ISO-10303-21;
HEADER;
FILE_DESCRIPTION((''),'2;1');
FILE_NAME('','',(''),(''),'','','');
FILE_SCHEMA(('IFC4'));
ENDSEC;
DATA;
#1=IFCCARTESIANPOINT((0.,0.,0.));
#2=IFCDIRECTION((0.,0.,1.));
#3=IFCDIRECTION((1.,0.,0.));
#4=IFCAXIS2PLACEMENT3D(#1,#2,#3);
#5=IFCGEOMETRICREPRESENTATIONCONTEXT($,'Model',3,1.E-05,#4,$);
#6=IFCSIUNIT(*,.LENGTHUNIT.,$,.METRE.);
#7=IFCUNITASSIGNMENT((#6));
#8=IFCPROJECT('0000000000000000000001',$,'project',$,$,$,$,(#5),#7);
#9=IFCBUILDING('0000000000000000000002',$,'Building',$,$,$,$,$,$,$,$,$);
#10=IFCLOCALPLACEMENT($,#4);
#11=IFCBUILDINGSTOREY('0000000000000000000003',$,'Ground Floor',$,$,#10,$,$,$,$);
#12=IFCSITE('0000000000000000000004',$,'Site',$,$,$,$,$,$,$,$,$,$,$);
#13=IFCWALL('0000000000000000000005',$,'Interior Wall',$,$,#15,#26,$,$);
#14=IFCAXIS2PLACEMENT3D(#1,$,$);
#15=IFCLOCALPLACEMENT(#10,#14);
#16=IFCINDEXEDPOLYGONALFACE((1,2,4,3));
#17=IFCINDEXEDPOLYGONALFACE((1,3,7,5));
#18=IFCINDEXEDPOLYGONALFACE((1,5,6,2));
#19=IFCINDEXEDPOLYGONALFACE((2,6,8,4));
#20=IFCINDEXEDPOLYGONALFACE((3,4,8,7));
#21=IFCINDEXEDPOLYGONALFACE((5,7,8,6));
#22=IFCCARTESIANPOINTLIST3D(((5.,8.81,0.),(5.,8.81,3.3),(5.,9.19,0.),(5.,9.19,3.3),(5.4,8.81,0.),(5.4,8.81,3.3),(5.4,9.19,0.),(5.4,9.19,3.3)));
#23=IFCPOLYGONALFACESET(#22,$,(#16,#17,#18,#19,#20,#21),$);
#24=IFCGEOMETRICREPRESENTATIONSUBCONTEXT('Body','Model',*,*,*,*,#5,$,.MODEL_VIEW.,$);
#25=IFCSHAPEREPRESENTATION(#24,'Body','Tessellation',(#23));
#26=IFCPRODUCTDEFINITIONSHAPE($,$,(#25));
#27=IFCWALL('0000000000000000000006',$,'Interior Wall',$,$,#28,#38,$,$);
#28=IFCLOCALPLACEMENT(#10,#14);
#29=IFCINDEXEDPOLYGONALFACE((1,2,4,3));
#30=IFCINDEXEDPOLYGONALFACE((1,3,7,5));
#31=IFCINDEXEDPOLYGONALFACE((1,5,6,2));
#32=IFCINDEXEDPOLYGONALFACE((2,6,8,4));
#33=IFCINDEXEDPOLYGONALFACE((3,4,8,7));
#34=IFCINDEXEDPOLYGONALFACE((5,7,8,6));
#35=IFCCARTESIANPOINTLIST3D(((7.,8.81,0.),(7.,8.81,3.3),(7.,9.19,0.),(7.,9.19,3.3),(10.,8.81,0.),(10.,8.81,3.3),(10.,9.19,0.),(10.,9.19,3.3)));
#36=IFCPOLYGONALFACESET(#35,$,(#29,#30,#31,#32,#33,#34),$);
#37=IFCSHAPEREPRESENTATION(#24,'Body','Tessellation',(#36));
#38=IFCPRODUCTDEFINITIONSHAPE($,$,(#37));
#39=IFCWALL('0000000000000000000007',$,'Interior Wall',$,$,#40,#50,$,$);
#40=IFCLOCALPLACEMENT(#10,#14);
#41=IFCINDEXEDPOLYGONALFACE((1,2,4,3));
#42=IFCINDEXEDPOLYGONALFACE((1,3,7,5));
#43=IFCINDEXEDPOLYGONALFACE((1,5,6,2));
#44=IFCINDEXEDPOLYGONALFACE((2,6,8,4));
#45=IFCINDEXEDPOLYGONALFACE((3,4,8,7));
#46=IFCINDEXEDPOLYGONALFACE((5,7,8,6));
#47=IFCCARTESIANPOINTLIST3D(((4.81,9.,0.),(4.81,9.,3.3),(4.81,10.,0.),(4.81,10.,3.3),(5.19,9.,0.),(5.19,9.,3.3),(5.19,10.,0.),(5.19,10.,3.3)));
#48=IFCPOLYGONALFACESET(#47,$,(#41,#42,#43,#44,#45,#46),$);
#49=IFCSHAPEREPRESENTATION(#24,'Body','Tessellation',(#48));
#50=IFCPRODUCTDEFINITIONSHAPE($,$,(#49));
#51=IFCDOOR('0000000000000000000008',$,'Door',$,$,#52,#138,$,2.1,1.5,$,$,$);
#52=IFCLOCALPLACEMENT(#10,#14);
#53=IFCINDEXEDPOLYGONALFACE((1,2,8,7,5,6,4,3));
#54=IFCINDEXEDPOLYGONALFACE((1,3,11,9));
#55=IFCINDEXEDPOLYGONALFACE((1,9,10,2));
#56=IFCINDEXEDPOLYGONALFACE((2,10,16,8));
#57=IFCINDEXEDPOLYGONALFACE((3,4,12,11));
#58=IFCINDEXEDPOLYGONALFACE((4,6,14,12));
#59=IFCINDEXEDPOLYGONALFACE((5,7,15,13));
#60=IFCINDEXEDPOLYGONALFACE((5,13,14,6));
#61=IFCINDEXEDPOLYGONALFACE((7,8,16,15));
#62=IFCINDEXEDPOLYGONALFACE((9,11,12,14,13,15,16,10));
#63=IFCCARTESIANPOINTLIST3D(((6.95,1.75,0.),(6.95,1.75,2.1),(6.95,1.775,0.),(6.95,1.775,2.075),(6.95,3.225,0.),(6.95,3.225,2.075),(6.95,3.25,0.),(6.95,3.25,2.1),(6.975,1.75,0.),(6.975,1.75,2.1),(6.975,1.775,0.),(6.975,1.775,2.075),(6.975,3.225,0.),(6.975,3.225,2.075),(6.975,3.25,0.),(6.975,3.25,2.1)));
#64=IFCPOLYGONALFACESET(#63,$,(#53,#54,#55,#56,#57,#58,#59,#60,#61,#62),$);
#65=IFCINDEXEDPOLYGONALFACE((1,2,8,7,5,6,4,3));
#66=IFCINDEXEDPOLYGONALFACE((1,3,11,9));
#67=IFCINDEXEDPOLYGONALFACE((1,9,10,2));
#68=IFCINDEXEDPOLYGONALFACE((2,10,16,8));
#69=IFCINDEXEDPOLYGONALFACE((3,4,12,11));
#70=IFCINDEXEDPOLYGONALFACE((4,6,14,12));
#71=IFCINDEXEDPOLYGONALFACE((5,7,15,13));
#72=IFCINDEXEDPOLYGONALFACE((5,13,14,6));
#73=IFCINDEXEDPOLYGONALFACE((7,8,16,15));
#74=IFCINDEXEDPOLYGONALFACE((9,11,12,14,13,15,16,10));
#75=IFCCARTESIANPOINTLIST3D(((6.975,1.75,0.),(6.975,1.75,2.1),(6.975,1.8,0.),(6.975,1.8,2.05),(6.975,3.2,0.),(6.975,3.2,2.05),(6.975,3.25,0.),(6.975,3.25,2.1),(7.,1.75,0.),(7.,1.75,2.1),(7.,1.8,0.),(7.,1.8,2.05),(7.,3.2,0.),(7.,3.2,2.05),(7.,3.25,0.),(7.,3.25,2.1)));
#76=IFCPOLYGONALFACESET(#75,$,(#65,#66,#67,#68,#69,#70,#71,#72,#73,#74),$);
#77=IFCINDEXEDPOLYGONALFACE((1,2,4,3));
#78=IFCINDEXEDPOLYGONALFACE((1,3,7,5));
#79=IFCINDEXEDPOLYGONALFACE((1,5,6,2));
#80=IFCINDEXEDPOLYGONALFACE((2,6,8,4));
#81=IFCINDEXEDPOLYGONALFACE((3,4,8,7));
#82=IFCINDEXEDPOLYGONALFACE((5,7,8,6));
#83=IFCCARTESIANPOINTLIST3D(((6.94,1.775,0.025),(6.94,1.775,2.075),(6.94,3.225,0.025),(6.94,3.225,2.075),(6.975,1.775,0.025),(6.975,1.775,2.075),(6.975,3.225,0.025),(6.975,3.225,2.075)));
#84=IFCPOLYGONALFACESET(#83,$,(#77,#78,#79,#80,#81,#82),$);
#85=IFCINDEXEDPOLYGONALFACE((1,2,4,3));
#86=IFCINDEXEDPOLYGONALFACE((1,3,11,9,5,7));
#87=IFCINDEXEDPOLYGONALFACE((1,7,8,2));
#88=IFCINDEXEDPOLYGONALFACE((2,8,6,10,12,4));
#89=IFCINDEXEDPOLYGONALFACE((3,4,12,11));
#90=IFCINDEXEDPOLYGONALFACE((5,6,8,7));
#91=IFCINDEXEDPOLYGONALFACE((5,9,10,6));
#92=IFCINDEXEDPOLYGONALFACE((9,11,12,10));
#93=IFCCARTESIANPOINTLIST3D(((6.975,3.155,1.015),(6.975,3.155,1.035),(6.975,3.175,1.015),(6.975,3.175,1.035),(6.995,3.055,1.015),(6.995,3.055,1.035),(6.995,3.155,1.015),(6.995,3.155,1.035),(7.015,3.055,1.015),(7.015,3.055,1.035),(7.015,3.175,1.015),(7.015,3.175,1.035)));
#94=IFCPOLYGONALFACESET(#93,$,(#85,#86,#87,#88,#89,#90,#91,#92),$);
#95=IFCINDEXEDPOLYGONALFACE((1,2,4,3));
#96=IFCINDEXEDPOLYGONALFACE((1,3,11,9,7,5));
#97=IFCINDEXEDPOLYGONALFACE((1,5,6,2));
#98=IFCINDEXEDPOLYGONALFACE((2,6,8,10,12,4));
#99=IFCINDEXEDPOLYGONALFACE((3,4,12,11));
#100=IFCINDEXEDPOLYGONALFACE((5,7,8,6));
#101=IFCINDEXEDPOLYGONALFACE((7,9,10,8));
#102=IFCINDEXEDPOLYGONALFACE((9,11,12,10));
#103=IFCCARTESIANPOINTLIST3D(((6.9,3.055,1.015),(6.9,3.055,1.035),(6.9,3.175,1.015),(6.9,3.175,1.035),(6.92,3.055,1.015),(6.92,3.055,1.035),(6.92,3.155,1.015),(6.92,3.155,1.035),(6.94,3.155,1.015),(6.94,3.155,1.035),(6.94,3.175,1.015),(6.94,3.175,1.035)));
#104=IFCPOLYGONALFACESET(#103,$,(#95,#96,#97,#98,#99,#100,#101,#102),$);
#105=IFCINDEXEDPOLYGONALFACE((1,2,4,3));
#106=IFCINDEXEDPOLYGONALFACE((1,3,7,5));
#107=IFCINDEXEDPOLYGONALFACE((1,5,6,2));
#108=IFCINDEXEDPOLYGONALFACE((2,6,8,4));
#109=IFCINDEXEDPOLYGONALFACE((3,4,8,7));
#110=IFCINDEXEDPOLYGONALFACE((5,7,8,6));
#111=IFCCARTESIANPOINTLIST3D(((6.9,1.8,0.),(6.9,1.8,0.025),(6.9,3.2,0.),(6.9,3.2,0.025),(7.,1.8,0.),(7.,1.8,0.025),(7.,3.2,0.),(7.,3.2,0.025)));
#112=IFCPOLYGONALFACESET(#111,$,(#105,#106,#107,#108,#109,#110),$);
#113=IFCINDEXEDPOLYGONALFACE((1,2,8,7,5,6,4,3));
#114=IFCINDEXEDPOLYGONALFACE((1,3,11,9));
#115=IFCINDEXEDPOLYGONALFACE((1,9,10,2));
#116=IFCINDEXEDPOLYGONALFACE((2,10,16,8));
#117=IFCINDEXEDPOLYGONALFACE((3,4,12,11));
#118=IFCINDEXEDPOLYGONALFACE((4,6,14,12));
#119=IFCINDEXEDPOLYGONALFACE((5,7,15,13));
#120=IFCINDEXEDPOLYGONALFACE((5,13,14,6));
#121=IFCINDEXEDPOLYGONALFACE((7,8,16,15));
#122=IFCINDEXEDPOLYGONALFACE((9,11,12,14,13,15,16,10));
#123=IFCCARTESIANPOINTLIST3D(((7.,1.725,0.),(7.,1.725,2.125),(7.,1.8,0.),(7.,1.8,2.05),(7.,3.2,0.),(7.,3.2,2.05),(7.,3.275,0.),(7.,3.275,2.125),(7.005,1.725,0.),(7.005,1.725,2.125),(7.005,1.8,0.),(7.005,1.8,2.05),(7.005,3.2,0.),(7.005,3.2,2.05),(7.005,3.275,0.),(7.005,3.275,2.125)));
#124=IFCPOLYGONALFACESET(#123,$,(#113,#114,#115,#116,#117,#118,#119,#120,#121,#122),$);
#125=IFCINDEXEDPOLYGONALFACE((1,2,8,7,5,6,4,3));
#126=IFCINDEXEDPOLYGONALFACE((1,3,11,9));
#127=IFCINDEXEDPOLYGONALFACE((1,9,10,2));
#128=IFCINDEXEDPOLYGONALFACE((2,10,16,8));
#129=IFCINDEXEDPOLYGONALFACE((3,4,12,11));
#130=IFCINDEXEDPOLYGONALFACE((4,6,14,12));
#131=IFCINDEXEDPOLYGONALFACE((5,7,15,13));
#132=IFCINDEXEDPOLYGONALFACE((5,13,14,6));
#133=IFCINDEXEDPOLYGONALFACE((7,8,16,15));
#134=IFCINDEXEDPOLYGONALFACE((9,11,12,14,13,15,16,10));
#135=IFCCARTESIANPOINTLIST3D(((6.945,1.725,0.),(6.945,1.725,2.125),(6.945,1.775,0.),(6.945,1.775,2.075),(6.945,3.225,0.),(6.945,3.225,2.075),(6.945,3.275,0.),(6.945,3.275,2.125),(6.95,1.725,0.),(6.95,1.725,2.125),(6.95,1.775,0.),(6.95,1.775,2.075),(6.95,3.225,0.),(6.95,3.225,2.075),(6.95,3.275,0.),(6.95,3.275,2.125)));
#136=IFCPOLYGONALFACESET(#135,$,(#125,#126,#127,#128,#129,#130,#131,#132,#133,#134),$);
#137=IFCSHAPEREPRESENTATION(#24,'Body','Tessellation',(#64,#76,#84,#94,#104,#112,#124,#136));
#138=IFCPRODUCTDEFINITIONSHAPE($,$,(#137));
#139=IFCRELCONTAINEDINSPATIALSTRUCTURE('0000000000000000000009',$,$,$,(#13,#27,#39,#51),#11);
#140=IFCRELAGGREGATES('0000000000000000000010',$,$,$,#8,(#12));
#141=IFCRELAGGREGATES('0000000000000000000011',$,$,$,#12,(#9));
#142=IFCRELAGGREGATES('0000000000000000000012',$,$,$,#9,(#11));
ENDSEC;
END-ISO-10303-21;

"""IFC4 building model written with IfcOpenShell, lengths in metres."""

from ifc_helpers import new_model, si_unit, frame, origin_with_axes, place, context, subcontext, project, spatial, line, indexed_curve, outline, extrude, element, save


model = new_model("IFC4")

# Units and contexts
model_context = context("Model", 3, precision=1e-05, world=origin_with_axes())
body_context = subcontext(model_context, "Body", "Model", "MODEL_VIEW")
ifc_project = project(units=[si_unit("LENGTHUNIT", "METRE")], contexts=[model_context])

# Site, building, storey
site = spatial("IfcSite", under=ifc_project, Name="Site")
building = spatial("IfcBuilding", under=site, Name="Building")
storey_placement = place(None, origin_with_axes())
storey = spatial("IfcBuildingStorey", under=building, at=storey_placement, Name="Ground Floor")

# Walls
for number, where, z_axis, x_axis, name in (
    (1, (5.4, 9.0, 0.0), (0.0, 0.0, 1.0), (-1.0, 0.0, 0.0), "Interior Wall"),
):
    element("IfcWall", number, at=place(storey_placement, frame(where, z_axis=z_axis, x_axis=x_axis)), inside=storey, Name=name, context=body_context, shape_type="SweptSolid", body=[
        extrude(outline(indexed_curve([(0.0, 0.0), (0.0, 0.38), (0.4, 0.38), (0.4, 0.0), (0.0, 0.0)], self_intersect=False)), frame((0.0, -0.19, 0.0), z_axis=(0.0, 0.0, 1.0), x_axis=(1.0, 0.0, 0.0)), (0.0, 0.0, 1.0), 3.3),
    ])
wall_1_placement = place(storey_placement, frame((10.0, 9.0, 0.0), z_axis=(0.0, 0.0, 1.0), x_axis=(-1.0, 0.0, 0.0)))
element("IfcWall", 2, at=wall_1_placement, inside=storey, Name="Interior Wall", context=body_context, shape_type="SweptSolid", body=[
    extrude(outline(indexed_curve([(0.0, 0.0), (0.0, 0.38), (3.0, 0.38), (3.0, 0.0), (0.0, 0.0)], self_intersect=False)), frame((0.0, -0.19, 0.0), z_axis=(0.0, 0.0, 1.0), x_axis=(1.0, 0.0, 0.0)), (0.0, 0.0, 1.0), 3.3),
])
wall_2_placement = place(storey_placement, frame((5.0, 9.0, 0.0), z_axis=(0.0, 0.0, 1.0), x_axis=(0.0, 1.0, 0.0)))
element("IfcWall", 3, at=wall_2_placement, inside=storey, Name="Interior Wall", context=body_context, shape_type="SweptSolid", body=[
    extrude(outline(indexed_curve([(0.0, 0.0), (0.0, 0.38), (1.0, 0.38), (1.0, 0.0), (0.0, 0.0)], self_intersect=False)), frame((0.0, -0.19, 0.0), z_axis=(0.0, 0.0, 1.0), x_axis=(1.0, 0.0, 0.0)), (0.0, 0.0, 1.0), 3.3),
])

# Door
door_1_placement = place(storey_placement, frame((7.0, 1.75, 0.0), z_axis=(0.0, 0.0, 1.0), x_axis=(0.0, 1.0, 0.0)))
element("IfcDoor", 4, at=door_1_placement, inside=storey, Name="Door", OverallHeight=2.1, OverallWidth=1.5, context=body_context, shape_type="SweptSolid", body=[
    extrude(outline(indexed_curve([(0.0, 0.0), (0.0, 2.1), (1.5, 2.1), (1.5, 0.0), (1.475, 0.0), (1.475, 2.075), (0.025, 2.075), (0.025, 0.0)], segments=[line(1, 2, 3, 4, 5, 6, 7, 8, 1)])), frame((0.0, 0.025, 0.0), z_axis=(0.0, -1.0, 0.0), x_axis=(1.0, 0.0, 0.0)), (0.0, 0.0, -1.0), 0.025),
    extrude(outline(indexed_curve([(0.0, 0.0), (0.0, 2.1), (1.5, 2.1), (1.5, 0.0), (1.45, 0.0), (1.45, 2.05), (0.05, 2.05), (0.05, 0.0)], segments=[line(1, 2, 3, 4, 5, 6, 7, 8, 1)])), frame((0.0, 0.0, 0.0), z_axis=(0.0, -1.0, 0.0), x_axis=(1.0, 0.0, 0.0)), (0.0, 0.0, -1.0), 0.025),
    extrude(outline(indexed_curve([(0.0, 0.0), (1.45, 0.0), (1.45, 0.035), (0.0, 0.035)], segments=[line(1, 2, 3, 4, 1)])), frame((0.025, 0.025, 0.025), z_axis=(0.0, 0.0, 1.0), x_axis=(1.0, 0.0, 0.0)), (0.0, 0.0, 1.0), 2.05),
    extrude(outline(indexed_curve([(0.0, 0.0), (0.0, -0.04), (-0.12, -0.04), (-0.12, -0.02), (-0.02, -0.02), (-0.02, 0.0)], segments=[line(1, 2, 3, 4, 5, 6, 1)])), frame((1.425, 0.025, 1.015), z_axis=(0.0, 0.0, 1.0), x_axis=(1.0, 0.0, 0.0)), (0.0, 0.0, 1.0), 0.02),
    extrude(outline(indexed_curve([(0.0, 0.0), (0.0, 0.04), (-0.12, 0.04), (-0.12, 0.02), (-0.02, 0.02), (-0.02, 0.0)], segments=[line(1, 2, 3, 4, 5, 6, 1)])), frame((1.425, 0.06, 1.015), z_axis=(0.0, 0.0, 1.0), x_axis=(1.0, 0.0, 0.0)), (0.0, 0.0, 1.0), 0.02),
    extrude(outline(indexed_curve([(0.0, 0.0), (1.4, 0.0), (1.4, 0.1), (0.0, 0.1)], segments=[line(1, 2, 3, 4, 1)])), frame((0.05, 0.0, 0.0), z_axis=(0.0, 0.0, 1.0), x_axis=(1.0, 0.0, 0.0)), (0.0, 0.0, 1.0), 0.025),
    extrude(outline(indexed_curve([(0.0, 0.0), (0.0, 2.125), (1.55, 2.125), (1.55, 0.0), (1.475, 0.0), (1.475, 2.05), (0.075, 2.05), (0.075, 0.0)], segments=[line(1, 2, 3, 4, 5, 6, 7, 8, 1)])), frame((-0.025, -0.005, 0.0), z_axis=(0.0, -1.0, 0.0), x_axis=(1.0, 0.0, 0.0)), (0.0, 0.0, -1.0), 0.005),
    extrude(outline(indexed_curve([(0.0, 0.0), (0.0, 2.125), (1.55, 2.125), (1.55, 0.0), (1.5, 0.0), (1.5, 2.075), (0.05, 2.075), (0.05, 0.0)], segments=[line(1, 2, 3, 4, 5, 6, 7, 8, 1)])), frame((-0.025, 0.05, 0.0), z_axis=(0.0, -1.0, 0.0), x_axis=(1.0, 0.0, 0.0)), (0.0, 0.0, -1.0), 0.005),
])

save(model, "model.ifc")
